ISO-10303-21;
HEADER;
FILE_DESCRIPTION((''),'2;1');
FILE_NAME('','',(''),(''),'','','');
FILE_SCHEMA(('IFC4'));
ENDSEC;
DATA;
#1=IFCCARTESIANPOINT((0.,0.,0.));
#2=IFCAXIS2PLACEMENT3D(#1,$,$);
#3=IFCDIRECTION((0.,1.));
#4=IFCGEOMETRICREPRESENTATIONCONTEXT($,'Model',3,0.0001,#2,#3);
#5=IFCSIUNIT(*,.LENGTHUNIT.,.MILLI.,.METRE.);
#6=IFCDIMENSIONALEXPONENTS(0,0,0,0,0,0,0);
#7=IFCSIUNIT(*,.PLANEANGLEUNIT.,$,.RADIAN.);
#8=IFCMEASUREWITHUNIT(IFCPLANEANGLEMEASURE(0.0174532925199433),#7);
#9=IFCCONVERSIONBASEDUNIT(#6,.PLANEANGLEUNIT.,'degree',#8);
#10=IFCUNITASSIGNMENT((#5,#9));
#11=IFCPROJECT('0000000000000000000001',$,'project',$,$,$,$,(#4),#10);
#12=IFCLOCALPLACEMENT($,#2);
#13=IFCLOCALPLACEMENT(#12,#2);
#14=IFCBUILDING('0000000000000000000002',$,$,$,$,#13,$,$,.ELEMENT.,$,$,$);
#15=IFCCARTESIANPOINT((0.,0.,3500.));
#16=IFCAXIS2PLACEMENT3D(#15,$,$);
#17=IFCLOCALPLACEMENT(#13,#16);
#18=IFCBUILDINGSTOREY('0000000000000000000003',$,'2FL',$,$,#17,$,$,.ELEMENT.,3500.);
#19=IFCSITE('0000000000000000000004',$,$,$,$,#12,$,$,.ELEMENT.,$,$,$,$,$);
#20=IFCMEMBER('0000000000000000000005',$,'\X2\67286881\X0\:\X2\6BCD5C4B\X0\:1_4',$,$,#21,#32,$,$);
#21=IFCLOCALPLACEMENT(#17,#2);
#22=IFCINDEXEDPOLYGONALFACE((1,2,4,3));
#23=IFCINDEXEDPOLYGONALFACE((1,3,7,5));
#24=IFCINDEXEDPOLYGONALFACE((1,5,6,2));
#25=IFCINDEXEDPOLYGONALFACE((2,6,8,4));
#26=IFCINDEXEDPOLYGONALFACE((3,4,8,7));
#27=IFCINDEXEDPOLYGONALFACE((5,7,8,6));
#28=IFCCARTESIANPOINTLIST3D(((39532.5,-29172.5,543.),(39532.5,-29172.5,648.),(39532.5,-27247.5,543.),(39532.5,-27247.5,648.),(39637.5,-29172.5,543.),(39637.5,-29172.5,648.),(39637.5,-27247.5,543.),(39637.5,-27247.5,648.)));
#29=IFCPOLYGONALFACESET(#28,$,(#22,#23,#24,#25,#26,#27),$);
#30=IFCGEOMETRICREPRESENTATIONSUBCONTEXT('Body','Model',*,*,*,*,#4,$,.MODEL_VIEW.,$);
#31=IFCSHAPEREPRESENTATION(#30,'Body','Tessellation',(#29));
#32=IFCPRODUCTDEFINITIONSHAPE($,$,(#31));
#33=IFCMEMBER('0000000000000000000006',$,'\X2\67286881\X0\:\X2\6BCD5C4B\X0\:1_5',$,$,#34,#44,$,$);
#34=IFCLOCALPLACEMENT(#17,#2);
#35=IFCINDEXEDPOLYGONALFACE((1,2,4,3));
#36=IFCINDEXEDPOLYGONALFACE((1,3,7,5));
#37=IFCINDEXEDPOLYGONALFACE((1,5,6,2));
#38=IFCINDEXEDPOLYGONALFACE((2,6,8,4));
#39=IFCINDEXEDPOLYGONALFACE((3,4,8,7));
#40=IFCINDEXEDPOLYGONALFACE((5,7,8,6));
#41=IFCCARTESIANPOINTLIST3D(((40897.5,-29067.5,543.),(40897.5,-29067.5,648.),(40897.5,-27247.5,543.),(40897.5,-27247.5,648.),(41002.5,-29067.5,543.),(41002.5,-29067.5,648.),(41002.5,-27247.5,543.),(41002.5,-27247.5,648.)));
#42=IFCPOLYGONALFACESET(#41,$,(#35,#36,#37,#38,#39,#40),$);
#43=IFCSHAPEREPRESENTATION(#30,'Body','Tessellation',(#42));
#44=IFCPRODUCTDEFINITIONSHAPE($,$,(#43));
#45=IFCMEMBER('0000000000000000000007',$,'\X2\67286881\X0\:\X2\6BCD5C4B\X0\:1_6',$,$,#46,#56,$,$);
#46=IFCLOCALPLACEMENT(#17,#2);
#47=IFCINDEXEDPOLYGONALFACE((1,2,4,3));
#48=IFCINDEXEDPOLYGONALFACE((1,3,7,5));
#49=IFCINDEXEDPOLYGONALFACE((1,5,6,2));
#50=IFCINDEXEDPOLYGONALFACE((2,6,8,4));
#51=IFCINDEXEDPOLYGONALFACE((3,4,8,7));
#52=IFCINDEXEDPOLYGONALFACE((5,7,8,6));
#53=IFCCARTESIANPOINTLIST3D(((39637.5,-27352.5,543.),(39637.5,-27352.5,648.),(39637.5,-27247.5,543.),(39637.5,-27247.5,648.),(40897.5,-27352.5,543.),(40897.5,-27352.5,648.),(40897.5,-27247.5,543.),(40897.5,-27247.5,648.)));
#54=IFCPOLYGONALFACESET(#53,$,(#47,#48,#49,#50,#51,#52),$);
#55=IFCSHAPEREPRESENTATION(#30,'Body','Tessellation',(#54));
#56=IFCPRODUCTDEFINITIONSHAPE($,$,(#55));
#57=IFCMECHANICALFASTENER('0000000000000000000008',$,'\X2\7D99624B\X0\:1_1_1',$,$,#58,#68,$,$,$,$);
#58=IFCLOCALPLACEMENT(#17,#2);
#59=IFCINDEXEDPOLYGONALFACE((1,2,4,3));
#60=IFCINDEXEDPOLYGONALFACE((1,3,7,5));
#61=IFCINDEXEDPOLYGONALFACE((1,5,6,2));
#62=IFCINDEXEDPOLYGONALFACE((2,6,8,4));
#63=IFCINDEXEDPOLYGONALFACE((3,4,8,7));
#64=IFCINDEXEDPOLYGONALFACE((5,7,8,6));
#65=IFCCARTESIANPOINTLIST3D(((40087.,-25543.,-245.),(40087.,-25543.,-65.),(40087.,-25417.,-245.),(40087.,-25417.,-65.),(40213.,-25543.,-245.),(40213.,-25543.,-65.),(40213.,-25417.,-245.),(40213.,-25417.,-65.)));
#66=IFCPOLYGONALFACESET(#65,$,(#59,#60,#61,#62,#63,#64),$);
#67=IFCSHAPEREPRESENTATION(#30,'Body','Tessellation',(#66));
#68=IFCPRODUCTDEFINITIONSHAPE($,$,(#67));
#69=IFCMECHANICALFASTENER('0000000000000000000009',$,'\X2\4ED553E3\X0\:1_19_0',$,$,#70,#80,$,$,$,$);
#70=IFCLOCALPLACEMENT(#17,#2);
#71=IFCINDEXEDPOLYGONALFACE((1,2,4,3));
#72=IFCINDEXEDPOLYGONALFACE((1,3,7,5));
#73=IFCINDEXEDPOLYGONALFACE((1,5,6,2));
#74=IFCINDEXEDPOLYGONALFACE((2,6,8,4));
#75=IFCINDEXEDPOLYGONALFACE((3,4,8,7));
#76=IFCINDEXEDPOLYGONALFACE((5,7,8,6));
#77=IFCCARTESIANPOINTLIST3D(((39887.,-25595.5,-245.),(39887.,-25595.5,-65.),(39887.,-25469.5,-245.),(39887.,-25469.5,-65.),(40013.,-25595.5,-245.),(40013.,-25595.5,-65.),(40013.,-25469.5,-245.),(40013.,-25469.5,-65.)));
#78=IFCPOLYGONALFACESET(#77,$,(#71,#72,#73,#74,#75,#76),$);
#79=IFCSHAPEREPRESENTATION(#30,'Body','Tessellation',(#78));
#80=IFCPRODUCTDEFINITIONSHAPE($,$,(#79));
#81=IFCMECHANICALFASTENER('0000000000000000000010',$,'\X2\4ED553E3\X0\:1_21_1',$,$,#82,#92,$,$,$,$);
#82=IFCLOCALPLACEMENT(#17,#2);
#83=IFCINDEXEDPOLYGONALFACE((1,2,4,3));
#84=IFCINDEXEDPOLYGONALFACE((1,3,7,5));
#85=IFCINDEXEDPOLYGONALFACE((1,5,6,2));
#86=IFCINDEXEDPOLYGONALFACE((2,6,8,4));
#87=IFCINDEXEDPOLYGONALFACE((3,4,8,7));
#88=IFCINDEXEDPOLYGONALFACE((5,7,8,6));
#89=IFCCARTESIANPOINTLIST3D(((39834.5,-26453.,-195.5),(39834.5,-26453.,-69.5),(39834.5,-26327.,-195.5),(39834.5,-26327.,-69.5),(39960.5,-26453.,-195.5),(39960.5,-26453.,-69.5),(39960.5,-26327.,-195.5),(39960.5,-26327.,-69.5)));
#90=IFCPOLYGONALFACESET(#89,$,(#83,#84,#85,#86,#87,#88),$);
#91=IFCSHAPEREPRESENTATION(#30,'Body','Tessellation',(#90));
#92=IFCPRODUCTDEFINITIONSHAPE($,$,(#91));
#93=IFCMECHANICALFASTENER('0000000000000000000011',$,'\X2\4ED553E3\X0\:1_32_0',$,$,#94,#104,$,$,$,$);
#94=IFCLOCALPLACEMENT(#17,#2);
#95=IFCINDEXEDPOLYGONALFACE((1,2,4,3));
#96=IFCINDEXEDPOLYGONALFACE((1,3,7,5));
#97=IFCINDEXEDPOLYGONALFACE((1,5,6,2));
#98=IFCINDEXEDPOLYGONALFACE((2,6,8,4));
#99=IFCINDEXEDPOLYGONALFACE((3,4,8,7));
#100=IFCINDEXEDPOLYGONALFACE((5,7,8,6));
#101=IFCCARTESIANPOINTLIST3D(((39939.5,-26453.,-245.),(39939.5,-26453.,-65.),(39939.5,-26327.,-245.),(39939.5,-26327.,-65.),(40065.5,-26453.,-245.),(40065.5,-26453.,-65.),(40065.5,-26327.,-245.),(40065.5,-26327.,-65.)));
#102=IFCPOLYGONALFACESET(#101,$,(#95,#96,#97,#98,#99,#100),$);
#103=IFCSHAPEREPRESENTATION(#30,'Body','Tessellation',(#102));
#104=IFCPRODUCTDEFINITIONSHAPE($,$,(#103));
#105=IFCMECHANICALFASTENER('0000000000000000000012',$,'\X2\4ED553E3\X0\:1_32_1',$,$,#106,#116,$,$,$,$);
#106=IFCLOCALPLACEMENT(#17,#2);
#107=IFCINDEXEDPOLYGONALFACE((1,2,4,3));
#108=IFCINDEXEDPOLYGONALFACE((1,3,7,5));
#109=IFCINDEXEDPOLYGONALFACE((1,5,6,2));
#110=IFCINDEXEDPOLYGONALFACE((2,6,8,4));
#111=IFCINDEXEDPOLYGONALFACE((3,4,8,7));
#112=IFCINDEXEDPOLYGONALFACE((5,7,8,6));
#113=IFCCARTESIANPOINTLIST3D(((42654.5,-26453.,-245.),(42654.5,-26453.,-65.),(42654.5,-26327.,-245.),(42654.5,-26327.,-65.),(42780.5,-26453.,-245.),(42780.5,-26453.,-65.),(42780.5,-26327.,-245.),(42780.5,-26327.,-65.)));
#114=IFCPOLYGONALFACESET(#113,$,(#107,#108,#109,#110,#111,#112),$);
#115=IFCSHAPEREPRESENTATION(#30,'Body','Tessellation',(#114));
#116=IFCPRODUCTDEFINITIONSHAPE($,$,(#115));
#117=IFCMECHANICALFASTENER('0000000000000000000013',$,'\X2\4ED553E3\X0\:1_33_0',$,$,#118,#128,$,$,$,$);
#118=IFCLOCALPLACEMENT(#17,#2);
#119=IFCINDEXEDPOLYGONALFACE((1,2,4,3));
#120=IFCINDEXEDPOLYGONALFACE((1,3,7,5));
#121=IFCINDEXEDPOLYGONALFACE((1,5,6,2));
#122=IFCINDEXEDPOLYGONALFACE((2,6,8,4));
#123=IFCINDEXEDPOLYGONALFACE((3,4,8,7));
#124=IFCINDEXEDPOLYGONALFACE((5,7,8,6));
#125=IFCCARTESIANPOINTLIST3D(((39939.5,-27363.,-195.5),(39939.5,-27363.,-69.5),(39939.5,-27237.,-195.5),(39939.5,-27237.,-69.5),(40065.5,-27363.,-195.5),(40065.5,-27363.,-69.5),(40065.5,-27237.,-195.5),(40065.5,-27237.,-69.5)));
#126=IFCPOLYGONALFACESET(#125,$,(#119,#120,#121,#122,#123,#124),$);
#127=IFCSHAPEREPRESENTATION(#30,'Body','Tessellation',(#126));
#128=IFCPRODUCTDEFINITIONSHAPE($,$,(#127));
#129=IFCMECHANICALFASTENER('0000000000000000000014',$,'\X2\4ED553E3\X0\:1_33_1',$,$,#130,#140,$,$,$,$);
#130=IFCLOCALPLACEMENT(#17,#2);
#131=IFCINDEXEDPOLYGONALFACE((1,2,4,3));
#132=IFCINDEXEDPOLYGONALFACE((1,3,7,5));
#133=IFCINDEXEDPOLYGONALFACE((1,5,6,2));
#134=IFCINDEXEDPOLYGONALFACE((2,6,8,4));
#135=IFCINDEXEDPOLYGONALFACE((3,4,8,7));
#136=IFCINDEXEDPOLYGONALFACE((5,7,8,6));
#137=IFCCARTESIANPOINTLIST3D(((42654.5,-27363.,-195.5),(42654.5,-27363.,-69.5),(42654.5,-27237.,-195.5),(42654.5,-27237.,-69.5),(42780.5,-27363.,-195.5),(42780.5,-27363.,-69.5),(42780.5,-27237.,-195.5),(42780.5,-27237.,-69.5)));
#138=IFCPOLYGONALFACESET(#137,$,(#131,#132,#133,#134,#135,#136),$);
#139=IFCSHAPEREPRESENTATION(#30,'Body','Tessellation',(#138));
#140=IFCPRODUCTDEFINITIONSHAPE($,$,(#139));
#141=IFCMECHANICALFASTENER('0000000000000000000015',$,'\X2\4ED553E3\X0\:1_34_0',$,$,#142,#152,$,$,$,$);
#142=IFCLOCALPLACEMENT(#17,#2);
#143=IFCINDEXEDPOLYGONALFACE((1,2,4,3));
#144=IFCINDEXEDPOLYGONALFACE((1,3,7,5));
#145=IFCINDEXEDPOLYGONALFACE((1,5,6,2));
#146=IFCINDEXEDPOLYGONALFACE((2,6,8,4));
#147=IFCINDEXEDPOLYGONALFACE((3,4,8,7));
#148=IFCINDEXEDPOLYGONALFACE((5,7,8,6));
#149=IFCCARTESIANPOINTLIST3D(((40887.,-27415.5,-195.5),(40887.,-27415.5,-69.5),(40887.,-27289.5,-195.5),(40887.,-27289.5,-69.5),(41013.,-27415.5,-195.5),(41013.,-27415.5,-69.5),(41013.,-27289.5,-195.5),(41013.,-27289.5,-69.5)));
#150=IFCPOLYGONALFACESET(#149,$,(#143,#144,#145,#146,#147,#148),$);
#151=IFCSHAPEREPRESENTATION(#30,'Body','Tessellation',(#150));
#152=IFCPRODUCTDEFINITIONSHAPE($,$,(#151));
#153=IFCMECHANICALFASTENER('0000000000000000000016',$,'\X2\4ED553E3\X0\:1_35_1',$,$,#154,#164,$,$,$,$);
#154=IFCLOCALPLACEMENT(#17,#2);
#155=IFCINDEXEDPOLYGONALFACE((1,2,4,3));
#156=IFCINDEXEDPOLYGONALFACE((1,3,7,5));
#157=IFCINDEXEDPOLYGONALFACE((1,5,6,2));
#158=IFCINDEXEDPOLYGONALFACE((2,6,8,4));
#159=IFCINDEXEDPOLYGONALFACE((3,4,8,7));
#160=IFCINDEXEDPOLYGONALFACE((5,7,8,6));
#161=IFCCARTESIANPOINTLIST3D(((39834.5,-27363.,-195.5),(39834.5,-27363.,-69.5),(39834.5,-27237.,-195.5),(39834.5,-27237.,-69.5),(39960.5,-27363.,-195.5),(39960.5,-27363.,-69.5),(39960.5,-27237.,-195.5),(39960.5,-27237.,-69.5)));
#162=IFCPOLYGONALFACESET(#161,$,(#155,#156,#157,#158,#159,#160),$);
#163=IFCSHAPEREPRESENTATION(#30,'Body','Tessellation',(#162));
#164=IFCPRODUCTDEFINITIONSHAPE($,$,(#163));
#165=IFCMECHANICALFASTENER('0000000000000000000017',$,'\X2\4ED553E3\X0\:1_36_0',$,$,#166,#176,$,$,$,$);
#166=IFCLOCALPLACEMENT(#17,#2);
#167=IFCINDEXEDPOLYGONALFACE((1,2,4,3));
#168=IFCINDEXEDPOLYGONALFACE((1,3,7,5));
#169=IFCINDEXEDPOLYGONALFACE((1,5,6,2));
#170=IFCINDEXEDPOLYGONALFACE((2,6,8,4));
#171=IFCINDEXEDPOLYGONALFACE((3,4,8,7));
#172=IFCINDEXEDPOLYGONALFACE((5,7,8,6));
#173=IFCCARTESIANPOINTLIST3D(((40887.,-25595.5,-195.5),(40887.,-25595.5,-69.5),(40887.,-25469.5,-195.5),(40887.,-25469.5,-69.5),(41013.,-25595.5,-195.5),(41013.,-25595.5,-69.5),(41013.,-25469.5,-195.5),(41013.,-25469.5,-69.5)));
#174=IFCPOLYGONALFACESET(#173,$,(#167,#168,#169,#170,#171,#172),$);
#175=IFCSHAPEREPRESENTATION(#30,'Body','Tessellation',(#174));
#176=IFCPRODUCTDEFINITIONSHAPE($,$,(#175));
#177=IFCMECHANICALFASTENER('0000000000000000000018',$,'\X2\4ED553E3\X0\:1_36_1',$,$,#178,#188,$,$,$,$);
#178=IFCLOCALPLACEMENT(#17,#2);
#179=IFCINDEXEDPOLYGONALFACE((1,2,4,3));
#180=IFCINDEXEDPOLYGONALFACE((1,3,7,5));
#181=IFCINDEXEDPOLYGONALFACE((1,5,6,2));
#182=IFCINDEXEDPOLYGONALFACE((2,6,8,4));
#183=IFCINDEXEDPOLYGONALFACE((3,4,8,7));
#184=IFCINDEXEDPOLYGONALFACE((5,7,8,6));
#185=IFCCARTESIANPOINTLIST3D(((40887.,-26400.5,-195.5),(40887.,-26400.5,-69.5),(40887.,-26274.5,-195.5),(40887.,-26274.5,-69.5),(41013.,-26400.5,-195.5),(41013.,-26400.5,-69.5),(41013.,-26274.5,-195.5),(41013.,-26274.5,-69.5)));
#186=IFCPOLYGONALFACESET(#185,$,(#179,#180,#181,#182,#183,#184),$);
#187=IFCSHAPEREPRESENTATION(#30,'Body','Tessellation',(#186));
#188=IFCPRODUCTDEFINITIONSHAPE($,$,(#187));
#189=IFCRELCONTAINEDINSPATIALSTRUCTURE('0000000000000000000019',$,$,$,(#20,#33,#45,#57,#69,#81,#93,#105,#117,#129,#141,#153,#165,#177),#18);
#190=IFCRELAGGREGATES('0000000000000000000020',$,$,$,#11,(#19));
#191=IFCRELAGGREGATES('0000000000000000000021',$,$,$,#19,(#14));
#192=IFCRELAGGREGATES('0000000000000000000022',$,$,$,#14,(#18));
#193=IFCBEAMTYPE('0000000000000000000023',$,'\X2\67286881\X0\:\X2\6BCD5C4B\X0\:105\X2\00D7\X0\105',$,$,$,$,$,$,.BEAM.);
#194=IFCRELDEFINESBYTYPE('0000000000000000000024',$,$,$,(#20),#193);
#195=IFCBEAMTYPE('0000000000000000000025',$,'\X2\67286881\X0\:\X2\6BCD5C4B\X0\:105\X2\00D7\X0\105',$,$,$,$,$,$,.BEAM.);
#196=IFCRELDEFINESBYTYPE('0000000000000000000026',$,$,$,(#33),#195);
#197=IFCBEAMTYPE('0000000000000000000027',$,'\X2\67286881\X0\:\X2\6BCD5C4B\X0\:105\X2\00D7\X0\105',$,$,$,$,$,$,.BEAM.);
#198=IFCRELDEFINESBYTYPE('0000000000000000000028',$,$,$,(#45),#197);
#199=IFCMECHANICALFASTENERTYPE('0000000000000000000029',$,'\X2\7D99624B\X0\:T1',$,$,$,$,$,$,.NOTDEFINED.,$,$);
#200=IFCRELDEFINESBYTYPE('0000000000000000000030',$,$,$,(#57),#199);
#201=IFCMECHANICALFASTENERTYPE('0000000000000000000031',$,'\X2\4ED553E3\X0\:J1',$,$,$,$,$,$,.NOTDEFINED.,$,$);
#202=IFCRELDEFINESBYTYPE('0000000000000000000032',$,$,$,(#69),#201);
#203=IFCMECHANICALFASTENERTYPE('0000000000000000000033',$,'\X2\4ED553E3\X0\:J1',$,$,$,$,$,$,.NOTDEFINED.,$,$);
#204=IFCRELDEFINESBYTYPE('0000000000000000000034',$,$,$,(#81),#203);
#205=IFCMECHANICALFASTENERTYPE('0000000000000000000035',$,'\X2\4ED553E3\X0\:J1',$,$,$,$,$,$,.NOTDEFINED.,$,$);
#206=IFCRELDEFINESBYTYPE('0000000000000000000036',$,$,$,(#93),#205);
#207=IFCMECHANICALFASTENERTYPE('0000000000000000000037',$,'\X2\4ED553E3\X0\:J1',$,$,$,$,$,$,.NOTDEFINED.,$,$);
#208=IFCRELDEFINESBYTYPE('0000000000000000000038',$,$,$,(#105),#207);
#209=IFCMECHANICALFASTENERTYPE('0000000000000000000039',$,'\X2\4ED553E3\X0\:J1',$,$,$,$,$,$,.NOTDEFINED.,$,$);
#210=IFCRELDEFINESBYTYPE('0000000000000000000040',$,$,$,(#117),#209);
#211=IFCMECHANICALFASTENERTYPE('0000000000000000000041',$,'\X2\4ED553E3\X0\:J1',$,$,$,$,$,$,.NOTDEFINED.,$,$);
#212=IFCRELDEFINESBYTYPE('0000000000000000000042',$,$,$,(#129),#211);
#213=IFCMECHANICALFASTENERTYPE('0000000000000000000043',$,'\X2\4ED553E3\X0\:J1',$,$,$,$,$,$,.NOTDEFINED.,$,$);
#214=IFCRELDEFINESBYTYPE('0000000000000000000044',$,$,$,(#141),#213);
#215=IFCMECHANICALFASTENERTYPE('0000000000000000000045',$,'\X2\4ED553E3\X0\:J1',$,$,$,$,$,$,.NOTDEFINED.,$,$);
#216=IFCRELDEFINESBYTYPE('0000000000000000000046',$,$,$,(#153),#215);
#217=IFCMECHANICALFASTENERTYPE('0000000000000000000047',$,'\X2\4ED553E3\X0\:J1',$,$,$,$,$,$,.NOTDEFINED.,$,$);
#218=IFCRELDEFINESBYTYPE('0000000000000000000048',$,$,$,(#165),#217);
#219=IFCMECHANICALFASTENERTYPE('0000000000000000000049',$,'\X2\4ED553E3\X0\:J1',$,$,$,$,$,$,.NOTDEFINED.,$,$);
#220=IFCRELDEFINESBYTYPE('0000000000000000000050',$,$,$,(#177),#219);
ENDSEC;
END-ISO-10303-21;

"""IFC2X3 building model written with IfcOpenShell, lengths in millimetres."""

from ifc_helpers import new_model, entity, si_unit, converted_unit, direction, frame, origin, origin_with_axes, origin_2d, place, context, subcontext, project, spatial, rectangle, extrude, type_object, element, save


model = new_model("IFC2X3")

# Units and contexts
model_context = context("Model", 3, precision=0.0001, world=origin(), true_north=direction((0.0, 1.0)))
body_context = subcontext(model_context, "Body", "Model", "MODEL_VIEW")
ifc_project = project(units=[si_unit("LENGTHUNIT", "METRE", prefix="MILLI"), converted_unit("PLANEANGLEUNIT", "degree", entity("IfcPlaneAngleMeasure", 0.0174532925199433), si_unit("PLANEANGLEUNIT", "RADIAN"), dimensions=[0, 0, 0, 0, 0, 0, 0])], contexts=[model_context])

# Site, building, storey
site_placement = place(None, origin())
site = spatial("IfcSite", under=ifc_project, at=site_placement, CompositionType="ELEMENT")
building_placement = place(site_placement, origin())
building = spatial("IfcBuilding", under=site, at=building_placement, CompositionType="ELEMENT")
storey_placement = place(building_placement, frame((0.0, 0.0, 3500.0)))
storey = spatial("IfcBuildingStorey", under=building, at=storey_placement, Name="2FL", CompositionType="ELEMENT", Elevation=3500.0)

# Members
beam_type_1 = type_object("IfcBeamType", Name="木梁:母屋:105×105", PredefinedType="BEAM")
member_1_placement = place(storey_placement, frame((39585.0, -27247.5, 595.5), z_axis=(0.0, -1.0, 0.0), x_axis=(-1.0, 0.0, 0.0)))
element("IfcMember", 1, at=member_1_placement, inside=storey, type_object=beam_type_1, Name="木梁:母屋:1_4", context=body_context, shape_type="SweptSolid", body=[
    extrude(rectangle(XDim=105.0, YDim=105.0, at=origin_2d()), origin_with_axes(), (0.0, 0.0, 1.0), 1925.0),
])
beam_type_2 = type_object("IfcBeamType", Name="木梁:母屋:105×105", PredefinedType="BEAM")
member_2_placement = place(storey_placement, frame((40950.0, -27247.5, 595.5), z_axis=(0.0, -1.0, 0.0), x_axis=(-1.0, 0.0, 0.0)))
element("IfcMember", 2, at=member_2_placement, inside=storey, type_object=beam_type_2, Name="木梁:母屋:1_5", context=body_context, shape_type="SweptSolid", body=[
    extrude(rectangle(XDim=105.0, YDim=105.0, at=origin_2d()), origin_with_axes(), (0.0, 0.0, 1.0), 1820.0),
])
beam_type_3 = type_object("IfcBeamType", Name="木梁:母屋:105×105", PredefinedType="BEAM")
member_3_placement = place(storey_placement, frame((39637.5, -27300.0, 595.5), z_axis=(1.0, 0.0, 0.0), x_axis=(0.0, -1.0, 0.0)))
element("IfcMember", 3, at=member_3_placement, inside=storey, type_object=beam_type_3, Name="木梁:母屋:1_6", context=body_context, shape_type="SweptSolid", body=[
    extrude(rectangle(XDim=105.0, YDim=105.0, at=origin_2d()), origin_with_axes(), (0.0, 0.0, 1.0), 1260.0),
])

# Mechanical fasteners
mechanical_fastener_type_1 = type_object("IfcMechanicalFastenerType", Name="継手:T1")
mechanical_fastener_1_placement = place(storey_placement, frame((40150.0, -25480.0, -245.0)))
element("IfcMechanicalFastener", 4, at=mechanical_fastener_1_placement, inside=storey, type_object=mechanical_fastener_type_1, Name="継手:1_1_1", context=body_context, shape_type="SweptSolid", body=[
    extrude(rectangle(XDim=126.0, YDim=126.0, at=origin_2d()), origin_with_axes(), (0.0, 0.0, 1.0), 180.0),
])
mechanical_fastener_type_2 = type_object("IfcMechanicalFastenerType", Name="仕口:J1")
mechanical_fastener_2_placement = place(storey_placement, frame((39950.0, -25532.5, -245.0)))
element("IfcMechanicalFastener", 5, at=mechanical_fastener_2_placement, inside=storey, type_object=mechanical_fastener_type_2, Name="仕口:1_19_0", context=body_context, shape_type="SweptSolid", body=[
    extrude(rectangle(XDim=126.0, YDim=126.0, at=origin_2d()), origin_with_axes(), (0.0, 0.0, 1.0), 180.0),
])
mechanical_fastener_type_3 = type_object("IfcMechanicalFastenerType", Name="仕口:J1")
mechanical_fastener_3_placement = place(storey_placement, frame((39897.5, -26390.0, -195.5)))
element("IfcMechanicalFastener", 6, at=mechanical_fastener_3_placement, inside=storey, type_object=mechanical_fastener_type_3, Name="仕口:1_21_1", context=body_context, shape_type="SweptSolid", body=[
    extrude(rectangle(XDim=126.0, YDim=126.0, at=origin_2d()), origin_with_axes(), (0.0, 0.0, 1.0), 126.0),
])
mechanical_fastener_type_4 = type_object("IfcMechanicalFastenerType", Name="仕口:J1")
mechanical_fastener_4_placement = place(storey_placement, frame((40002.5, -26390.0, -245.0)))
element("IfcMechanicalFastener", 7, at=mechanical_fastener_4_placement, inside=storey, type_object=mechanical_fastener_type_4, Name="仕口:1_32_0", context=body_context, shape_type="SweptSolid", body=[
    extrude(rectangle(XDim=126.0, YDim=126.0, at=origin_2d()), origin_with_axes(), (0.0, 0.0, 1.0), 180.0),
])
mechanical_fastener_type_5 = type_object("IfcMechanicalFastenerType", Name="仕口:J1")
mechanical_fastener_5_placement = place(storey_placement, frame((42717.5, -26390.0, -245.0)))
element("IfcMechanicalFastener", 8, at=mechanical_fastener_5_placement, inside=storey, type_object=mechanical_fastener_type_5, Name="仕口:1_32_1", context=body_context, shape_type="SweptSolid", body=[
    extrude(rectangle(XDim=126.0, YDim=126.0, at=origin_2d()), origin_with_axes(), (0.0, 0.0, 1.0), 180.0),
])
mechanical_fastener_type_6 = type_object("IfcMechanicalFastenerType", Name="仕口:J1")
mechanical_fastener_6_placement = place(storey_placement, frame((40002.5, -27300.0, -195.5)))
element("IfcMechanicalFastener", 9, at=mechanical_fastener_6_placement, inside=storey, type_object=mechanical_fastener_type_6, Name="仕口:1_33_0", context=body_context, shape_type="SweptSolid", body=[
    extrude(rectangle(XDim=126.0, YDim=126.0, at=origin_2d()), origin_with_axes(), (0.0, 0.0, 1.0), 126.0),
])
mechanical_fastener_type_7 = type_object("IfcMechanicalFastenerType", Name="仕口:J1")
mechanical_fastener_7_placement = place(storey_placement, frame((42717.5, -27300.0, -195.5)))
element("IfcMechanicalFastener", 10, at=mechanical_fastener_7_placement, inside=storey, type_object=mechanical_fastener_type_7, Name="仕口:1_33_1", context=body_context, shape_type="SweptSolid", body=[
    extrude(rectangle(XDim=126.0, YDim=126.0, at=origin_2d()), origin_with_axes(), (0.0, 0.0, 1.0), 126.0),
])
mechanical_fastener_type_8 = type_object("IfcMechanicalFastenerType", Name="仕口:J1")
mechanical_fastener_8_placement = place(storey_placement, frame((40950.0, -27352.5, -195.5)))
element("IfcMechanicalFastener", 11, at=mechanical_fastener_8_placement, inside=storey, type_object=mechanical_fastener_type_8, Name="仕口:1_34_0", context=body_context, shape_type="SweptSolid", body=[
    extrude(rectangle(XDim=126.0, YDim=126.0, at=origin_2d()), origin_with_axes(), (0.0, 0.0, 1.0), 126.0),
])
mechanical_fastener_type_9 = type_object("IfcMechanicalFastenerType", Name="仕口:J1")
mechanical_fastener_9_placement = place(storey_placement, frame((39897.5, -27300.0, -195.5)))
element("IfcMechanicalFastener", 12, at=mechanical_fastener_9_placement, inside=storey, type_object=mechanical_fastener_type_9, Name="仕口:1_35_1", context=body_context, shape_type="SweptSolid", body=[
    extrude(rectangle(XDim=126.0, YDim=126.0, at=origin_2d()), origin_with_axes(), (0.0, 0.0, 1.0), 126.0),
])
mechanical_fastener_type_10 = type_object("IfcMechanicalFastenerType", Name="仕口:J1")
mechanical_fastener_10_placement = place(storey_placement, frame((40950.0, -25532.5, -195.5)))
element("IfcMechanicalFastener", 13, at=mechanical_fastener_10_placement, inside=storey, type_object=mechanical_fastener_type_10, Name="仕口:1_36_0", context=body_context, shape_type="SweptSolid", body=[
    extrude(rectangle(XDim=126.0, YDim=126.0, at=origin_2d()), origin_with_axes(), (0.0, 0.0, 1.0), 126.0),
])
mechanical_fastener_type_11 = type_object("IfcMechanicalFastenerType", Name="仕口:J1")
mechanical_fastener_11_placement = place(storey_placement, frame((40950.0, -26337.5, -195.5)))
element("IfcMechanicalFastener", 14, at=mechanical_fastener_11_placement, inside=storey, type_object=mechanical_fastener_type_11, Name="仕口:1_36_1", context=body_context, shape_type="SweptSolid", body=[
    extrude(rectangle(XDim=126.0, YDim=126.0, at=origin_2d()), origin_with_axes(), (0.0, 0.0, 1.0), 126.0),
])

save(model, "model.ifc")
